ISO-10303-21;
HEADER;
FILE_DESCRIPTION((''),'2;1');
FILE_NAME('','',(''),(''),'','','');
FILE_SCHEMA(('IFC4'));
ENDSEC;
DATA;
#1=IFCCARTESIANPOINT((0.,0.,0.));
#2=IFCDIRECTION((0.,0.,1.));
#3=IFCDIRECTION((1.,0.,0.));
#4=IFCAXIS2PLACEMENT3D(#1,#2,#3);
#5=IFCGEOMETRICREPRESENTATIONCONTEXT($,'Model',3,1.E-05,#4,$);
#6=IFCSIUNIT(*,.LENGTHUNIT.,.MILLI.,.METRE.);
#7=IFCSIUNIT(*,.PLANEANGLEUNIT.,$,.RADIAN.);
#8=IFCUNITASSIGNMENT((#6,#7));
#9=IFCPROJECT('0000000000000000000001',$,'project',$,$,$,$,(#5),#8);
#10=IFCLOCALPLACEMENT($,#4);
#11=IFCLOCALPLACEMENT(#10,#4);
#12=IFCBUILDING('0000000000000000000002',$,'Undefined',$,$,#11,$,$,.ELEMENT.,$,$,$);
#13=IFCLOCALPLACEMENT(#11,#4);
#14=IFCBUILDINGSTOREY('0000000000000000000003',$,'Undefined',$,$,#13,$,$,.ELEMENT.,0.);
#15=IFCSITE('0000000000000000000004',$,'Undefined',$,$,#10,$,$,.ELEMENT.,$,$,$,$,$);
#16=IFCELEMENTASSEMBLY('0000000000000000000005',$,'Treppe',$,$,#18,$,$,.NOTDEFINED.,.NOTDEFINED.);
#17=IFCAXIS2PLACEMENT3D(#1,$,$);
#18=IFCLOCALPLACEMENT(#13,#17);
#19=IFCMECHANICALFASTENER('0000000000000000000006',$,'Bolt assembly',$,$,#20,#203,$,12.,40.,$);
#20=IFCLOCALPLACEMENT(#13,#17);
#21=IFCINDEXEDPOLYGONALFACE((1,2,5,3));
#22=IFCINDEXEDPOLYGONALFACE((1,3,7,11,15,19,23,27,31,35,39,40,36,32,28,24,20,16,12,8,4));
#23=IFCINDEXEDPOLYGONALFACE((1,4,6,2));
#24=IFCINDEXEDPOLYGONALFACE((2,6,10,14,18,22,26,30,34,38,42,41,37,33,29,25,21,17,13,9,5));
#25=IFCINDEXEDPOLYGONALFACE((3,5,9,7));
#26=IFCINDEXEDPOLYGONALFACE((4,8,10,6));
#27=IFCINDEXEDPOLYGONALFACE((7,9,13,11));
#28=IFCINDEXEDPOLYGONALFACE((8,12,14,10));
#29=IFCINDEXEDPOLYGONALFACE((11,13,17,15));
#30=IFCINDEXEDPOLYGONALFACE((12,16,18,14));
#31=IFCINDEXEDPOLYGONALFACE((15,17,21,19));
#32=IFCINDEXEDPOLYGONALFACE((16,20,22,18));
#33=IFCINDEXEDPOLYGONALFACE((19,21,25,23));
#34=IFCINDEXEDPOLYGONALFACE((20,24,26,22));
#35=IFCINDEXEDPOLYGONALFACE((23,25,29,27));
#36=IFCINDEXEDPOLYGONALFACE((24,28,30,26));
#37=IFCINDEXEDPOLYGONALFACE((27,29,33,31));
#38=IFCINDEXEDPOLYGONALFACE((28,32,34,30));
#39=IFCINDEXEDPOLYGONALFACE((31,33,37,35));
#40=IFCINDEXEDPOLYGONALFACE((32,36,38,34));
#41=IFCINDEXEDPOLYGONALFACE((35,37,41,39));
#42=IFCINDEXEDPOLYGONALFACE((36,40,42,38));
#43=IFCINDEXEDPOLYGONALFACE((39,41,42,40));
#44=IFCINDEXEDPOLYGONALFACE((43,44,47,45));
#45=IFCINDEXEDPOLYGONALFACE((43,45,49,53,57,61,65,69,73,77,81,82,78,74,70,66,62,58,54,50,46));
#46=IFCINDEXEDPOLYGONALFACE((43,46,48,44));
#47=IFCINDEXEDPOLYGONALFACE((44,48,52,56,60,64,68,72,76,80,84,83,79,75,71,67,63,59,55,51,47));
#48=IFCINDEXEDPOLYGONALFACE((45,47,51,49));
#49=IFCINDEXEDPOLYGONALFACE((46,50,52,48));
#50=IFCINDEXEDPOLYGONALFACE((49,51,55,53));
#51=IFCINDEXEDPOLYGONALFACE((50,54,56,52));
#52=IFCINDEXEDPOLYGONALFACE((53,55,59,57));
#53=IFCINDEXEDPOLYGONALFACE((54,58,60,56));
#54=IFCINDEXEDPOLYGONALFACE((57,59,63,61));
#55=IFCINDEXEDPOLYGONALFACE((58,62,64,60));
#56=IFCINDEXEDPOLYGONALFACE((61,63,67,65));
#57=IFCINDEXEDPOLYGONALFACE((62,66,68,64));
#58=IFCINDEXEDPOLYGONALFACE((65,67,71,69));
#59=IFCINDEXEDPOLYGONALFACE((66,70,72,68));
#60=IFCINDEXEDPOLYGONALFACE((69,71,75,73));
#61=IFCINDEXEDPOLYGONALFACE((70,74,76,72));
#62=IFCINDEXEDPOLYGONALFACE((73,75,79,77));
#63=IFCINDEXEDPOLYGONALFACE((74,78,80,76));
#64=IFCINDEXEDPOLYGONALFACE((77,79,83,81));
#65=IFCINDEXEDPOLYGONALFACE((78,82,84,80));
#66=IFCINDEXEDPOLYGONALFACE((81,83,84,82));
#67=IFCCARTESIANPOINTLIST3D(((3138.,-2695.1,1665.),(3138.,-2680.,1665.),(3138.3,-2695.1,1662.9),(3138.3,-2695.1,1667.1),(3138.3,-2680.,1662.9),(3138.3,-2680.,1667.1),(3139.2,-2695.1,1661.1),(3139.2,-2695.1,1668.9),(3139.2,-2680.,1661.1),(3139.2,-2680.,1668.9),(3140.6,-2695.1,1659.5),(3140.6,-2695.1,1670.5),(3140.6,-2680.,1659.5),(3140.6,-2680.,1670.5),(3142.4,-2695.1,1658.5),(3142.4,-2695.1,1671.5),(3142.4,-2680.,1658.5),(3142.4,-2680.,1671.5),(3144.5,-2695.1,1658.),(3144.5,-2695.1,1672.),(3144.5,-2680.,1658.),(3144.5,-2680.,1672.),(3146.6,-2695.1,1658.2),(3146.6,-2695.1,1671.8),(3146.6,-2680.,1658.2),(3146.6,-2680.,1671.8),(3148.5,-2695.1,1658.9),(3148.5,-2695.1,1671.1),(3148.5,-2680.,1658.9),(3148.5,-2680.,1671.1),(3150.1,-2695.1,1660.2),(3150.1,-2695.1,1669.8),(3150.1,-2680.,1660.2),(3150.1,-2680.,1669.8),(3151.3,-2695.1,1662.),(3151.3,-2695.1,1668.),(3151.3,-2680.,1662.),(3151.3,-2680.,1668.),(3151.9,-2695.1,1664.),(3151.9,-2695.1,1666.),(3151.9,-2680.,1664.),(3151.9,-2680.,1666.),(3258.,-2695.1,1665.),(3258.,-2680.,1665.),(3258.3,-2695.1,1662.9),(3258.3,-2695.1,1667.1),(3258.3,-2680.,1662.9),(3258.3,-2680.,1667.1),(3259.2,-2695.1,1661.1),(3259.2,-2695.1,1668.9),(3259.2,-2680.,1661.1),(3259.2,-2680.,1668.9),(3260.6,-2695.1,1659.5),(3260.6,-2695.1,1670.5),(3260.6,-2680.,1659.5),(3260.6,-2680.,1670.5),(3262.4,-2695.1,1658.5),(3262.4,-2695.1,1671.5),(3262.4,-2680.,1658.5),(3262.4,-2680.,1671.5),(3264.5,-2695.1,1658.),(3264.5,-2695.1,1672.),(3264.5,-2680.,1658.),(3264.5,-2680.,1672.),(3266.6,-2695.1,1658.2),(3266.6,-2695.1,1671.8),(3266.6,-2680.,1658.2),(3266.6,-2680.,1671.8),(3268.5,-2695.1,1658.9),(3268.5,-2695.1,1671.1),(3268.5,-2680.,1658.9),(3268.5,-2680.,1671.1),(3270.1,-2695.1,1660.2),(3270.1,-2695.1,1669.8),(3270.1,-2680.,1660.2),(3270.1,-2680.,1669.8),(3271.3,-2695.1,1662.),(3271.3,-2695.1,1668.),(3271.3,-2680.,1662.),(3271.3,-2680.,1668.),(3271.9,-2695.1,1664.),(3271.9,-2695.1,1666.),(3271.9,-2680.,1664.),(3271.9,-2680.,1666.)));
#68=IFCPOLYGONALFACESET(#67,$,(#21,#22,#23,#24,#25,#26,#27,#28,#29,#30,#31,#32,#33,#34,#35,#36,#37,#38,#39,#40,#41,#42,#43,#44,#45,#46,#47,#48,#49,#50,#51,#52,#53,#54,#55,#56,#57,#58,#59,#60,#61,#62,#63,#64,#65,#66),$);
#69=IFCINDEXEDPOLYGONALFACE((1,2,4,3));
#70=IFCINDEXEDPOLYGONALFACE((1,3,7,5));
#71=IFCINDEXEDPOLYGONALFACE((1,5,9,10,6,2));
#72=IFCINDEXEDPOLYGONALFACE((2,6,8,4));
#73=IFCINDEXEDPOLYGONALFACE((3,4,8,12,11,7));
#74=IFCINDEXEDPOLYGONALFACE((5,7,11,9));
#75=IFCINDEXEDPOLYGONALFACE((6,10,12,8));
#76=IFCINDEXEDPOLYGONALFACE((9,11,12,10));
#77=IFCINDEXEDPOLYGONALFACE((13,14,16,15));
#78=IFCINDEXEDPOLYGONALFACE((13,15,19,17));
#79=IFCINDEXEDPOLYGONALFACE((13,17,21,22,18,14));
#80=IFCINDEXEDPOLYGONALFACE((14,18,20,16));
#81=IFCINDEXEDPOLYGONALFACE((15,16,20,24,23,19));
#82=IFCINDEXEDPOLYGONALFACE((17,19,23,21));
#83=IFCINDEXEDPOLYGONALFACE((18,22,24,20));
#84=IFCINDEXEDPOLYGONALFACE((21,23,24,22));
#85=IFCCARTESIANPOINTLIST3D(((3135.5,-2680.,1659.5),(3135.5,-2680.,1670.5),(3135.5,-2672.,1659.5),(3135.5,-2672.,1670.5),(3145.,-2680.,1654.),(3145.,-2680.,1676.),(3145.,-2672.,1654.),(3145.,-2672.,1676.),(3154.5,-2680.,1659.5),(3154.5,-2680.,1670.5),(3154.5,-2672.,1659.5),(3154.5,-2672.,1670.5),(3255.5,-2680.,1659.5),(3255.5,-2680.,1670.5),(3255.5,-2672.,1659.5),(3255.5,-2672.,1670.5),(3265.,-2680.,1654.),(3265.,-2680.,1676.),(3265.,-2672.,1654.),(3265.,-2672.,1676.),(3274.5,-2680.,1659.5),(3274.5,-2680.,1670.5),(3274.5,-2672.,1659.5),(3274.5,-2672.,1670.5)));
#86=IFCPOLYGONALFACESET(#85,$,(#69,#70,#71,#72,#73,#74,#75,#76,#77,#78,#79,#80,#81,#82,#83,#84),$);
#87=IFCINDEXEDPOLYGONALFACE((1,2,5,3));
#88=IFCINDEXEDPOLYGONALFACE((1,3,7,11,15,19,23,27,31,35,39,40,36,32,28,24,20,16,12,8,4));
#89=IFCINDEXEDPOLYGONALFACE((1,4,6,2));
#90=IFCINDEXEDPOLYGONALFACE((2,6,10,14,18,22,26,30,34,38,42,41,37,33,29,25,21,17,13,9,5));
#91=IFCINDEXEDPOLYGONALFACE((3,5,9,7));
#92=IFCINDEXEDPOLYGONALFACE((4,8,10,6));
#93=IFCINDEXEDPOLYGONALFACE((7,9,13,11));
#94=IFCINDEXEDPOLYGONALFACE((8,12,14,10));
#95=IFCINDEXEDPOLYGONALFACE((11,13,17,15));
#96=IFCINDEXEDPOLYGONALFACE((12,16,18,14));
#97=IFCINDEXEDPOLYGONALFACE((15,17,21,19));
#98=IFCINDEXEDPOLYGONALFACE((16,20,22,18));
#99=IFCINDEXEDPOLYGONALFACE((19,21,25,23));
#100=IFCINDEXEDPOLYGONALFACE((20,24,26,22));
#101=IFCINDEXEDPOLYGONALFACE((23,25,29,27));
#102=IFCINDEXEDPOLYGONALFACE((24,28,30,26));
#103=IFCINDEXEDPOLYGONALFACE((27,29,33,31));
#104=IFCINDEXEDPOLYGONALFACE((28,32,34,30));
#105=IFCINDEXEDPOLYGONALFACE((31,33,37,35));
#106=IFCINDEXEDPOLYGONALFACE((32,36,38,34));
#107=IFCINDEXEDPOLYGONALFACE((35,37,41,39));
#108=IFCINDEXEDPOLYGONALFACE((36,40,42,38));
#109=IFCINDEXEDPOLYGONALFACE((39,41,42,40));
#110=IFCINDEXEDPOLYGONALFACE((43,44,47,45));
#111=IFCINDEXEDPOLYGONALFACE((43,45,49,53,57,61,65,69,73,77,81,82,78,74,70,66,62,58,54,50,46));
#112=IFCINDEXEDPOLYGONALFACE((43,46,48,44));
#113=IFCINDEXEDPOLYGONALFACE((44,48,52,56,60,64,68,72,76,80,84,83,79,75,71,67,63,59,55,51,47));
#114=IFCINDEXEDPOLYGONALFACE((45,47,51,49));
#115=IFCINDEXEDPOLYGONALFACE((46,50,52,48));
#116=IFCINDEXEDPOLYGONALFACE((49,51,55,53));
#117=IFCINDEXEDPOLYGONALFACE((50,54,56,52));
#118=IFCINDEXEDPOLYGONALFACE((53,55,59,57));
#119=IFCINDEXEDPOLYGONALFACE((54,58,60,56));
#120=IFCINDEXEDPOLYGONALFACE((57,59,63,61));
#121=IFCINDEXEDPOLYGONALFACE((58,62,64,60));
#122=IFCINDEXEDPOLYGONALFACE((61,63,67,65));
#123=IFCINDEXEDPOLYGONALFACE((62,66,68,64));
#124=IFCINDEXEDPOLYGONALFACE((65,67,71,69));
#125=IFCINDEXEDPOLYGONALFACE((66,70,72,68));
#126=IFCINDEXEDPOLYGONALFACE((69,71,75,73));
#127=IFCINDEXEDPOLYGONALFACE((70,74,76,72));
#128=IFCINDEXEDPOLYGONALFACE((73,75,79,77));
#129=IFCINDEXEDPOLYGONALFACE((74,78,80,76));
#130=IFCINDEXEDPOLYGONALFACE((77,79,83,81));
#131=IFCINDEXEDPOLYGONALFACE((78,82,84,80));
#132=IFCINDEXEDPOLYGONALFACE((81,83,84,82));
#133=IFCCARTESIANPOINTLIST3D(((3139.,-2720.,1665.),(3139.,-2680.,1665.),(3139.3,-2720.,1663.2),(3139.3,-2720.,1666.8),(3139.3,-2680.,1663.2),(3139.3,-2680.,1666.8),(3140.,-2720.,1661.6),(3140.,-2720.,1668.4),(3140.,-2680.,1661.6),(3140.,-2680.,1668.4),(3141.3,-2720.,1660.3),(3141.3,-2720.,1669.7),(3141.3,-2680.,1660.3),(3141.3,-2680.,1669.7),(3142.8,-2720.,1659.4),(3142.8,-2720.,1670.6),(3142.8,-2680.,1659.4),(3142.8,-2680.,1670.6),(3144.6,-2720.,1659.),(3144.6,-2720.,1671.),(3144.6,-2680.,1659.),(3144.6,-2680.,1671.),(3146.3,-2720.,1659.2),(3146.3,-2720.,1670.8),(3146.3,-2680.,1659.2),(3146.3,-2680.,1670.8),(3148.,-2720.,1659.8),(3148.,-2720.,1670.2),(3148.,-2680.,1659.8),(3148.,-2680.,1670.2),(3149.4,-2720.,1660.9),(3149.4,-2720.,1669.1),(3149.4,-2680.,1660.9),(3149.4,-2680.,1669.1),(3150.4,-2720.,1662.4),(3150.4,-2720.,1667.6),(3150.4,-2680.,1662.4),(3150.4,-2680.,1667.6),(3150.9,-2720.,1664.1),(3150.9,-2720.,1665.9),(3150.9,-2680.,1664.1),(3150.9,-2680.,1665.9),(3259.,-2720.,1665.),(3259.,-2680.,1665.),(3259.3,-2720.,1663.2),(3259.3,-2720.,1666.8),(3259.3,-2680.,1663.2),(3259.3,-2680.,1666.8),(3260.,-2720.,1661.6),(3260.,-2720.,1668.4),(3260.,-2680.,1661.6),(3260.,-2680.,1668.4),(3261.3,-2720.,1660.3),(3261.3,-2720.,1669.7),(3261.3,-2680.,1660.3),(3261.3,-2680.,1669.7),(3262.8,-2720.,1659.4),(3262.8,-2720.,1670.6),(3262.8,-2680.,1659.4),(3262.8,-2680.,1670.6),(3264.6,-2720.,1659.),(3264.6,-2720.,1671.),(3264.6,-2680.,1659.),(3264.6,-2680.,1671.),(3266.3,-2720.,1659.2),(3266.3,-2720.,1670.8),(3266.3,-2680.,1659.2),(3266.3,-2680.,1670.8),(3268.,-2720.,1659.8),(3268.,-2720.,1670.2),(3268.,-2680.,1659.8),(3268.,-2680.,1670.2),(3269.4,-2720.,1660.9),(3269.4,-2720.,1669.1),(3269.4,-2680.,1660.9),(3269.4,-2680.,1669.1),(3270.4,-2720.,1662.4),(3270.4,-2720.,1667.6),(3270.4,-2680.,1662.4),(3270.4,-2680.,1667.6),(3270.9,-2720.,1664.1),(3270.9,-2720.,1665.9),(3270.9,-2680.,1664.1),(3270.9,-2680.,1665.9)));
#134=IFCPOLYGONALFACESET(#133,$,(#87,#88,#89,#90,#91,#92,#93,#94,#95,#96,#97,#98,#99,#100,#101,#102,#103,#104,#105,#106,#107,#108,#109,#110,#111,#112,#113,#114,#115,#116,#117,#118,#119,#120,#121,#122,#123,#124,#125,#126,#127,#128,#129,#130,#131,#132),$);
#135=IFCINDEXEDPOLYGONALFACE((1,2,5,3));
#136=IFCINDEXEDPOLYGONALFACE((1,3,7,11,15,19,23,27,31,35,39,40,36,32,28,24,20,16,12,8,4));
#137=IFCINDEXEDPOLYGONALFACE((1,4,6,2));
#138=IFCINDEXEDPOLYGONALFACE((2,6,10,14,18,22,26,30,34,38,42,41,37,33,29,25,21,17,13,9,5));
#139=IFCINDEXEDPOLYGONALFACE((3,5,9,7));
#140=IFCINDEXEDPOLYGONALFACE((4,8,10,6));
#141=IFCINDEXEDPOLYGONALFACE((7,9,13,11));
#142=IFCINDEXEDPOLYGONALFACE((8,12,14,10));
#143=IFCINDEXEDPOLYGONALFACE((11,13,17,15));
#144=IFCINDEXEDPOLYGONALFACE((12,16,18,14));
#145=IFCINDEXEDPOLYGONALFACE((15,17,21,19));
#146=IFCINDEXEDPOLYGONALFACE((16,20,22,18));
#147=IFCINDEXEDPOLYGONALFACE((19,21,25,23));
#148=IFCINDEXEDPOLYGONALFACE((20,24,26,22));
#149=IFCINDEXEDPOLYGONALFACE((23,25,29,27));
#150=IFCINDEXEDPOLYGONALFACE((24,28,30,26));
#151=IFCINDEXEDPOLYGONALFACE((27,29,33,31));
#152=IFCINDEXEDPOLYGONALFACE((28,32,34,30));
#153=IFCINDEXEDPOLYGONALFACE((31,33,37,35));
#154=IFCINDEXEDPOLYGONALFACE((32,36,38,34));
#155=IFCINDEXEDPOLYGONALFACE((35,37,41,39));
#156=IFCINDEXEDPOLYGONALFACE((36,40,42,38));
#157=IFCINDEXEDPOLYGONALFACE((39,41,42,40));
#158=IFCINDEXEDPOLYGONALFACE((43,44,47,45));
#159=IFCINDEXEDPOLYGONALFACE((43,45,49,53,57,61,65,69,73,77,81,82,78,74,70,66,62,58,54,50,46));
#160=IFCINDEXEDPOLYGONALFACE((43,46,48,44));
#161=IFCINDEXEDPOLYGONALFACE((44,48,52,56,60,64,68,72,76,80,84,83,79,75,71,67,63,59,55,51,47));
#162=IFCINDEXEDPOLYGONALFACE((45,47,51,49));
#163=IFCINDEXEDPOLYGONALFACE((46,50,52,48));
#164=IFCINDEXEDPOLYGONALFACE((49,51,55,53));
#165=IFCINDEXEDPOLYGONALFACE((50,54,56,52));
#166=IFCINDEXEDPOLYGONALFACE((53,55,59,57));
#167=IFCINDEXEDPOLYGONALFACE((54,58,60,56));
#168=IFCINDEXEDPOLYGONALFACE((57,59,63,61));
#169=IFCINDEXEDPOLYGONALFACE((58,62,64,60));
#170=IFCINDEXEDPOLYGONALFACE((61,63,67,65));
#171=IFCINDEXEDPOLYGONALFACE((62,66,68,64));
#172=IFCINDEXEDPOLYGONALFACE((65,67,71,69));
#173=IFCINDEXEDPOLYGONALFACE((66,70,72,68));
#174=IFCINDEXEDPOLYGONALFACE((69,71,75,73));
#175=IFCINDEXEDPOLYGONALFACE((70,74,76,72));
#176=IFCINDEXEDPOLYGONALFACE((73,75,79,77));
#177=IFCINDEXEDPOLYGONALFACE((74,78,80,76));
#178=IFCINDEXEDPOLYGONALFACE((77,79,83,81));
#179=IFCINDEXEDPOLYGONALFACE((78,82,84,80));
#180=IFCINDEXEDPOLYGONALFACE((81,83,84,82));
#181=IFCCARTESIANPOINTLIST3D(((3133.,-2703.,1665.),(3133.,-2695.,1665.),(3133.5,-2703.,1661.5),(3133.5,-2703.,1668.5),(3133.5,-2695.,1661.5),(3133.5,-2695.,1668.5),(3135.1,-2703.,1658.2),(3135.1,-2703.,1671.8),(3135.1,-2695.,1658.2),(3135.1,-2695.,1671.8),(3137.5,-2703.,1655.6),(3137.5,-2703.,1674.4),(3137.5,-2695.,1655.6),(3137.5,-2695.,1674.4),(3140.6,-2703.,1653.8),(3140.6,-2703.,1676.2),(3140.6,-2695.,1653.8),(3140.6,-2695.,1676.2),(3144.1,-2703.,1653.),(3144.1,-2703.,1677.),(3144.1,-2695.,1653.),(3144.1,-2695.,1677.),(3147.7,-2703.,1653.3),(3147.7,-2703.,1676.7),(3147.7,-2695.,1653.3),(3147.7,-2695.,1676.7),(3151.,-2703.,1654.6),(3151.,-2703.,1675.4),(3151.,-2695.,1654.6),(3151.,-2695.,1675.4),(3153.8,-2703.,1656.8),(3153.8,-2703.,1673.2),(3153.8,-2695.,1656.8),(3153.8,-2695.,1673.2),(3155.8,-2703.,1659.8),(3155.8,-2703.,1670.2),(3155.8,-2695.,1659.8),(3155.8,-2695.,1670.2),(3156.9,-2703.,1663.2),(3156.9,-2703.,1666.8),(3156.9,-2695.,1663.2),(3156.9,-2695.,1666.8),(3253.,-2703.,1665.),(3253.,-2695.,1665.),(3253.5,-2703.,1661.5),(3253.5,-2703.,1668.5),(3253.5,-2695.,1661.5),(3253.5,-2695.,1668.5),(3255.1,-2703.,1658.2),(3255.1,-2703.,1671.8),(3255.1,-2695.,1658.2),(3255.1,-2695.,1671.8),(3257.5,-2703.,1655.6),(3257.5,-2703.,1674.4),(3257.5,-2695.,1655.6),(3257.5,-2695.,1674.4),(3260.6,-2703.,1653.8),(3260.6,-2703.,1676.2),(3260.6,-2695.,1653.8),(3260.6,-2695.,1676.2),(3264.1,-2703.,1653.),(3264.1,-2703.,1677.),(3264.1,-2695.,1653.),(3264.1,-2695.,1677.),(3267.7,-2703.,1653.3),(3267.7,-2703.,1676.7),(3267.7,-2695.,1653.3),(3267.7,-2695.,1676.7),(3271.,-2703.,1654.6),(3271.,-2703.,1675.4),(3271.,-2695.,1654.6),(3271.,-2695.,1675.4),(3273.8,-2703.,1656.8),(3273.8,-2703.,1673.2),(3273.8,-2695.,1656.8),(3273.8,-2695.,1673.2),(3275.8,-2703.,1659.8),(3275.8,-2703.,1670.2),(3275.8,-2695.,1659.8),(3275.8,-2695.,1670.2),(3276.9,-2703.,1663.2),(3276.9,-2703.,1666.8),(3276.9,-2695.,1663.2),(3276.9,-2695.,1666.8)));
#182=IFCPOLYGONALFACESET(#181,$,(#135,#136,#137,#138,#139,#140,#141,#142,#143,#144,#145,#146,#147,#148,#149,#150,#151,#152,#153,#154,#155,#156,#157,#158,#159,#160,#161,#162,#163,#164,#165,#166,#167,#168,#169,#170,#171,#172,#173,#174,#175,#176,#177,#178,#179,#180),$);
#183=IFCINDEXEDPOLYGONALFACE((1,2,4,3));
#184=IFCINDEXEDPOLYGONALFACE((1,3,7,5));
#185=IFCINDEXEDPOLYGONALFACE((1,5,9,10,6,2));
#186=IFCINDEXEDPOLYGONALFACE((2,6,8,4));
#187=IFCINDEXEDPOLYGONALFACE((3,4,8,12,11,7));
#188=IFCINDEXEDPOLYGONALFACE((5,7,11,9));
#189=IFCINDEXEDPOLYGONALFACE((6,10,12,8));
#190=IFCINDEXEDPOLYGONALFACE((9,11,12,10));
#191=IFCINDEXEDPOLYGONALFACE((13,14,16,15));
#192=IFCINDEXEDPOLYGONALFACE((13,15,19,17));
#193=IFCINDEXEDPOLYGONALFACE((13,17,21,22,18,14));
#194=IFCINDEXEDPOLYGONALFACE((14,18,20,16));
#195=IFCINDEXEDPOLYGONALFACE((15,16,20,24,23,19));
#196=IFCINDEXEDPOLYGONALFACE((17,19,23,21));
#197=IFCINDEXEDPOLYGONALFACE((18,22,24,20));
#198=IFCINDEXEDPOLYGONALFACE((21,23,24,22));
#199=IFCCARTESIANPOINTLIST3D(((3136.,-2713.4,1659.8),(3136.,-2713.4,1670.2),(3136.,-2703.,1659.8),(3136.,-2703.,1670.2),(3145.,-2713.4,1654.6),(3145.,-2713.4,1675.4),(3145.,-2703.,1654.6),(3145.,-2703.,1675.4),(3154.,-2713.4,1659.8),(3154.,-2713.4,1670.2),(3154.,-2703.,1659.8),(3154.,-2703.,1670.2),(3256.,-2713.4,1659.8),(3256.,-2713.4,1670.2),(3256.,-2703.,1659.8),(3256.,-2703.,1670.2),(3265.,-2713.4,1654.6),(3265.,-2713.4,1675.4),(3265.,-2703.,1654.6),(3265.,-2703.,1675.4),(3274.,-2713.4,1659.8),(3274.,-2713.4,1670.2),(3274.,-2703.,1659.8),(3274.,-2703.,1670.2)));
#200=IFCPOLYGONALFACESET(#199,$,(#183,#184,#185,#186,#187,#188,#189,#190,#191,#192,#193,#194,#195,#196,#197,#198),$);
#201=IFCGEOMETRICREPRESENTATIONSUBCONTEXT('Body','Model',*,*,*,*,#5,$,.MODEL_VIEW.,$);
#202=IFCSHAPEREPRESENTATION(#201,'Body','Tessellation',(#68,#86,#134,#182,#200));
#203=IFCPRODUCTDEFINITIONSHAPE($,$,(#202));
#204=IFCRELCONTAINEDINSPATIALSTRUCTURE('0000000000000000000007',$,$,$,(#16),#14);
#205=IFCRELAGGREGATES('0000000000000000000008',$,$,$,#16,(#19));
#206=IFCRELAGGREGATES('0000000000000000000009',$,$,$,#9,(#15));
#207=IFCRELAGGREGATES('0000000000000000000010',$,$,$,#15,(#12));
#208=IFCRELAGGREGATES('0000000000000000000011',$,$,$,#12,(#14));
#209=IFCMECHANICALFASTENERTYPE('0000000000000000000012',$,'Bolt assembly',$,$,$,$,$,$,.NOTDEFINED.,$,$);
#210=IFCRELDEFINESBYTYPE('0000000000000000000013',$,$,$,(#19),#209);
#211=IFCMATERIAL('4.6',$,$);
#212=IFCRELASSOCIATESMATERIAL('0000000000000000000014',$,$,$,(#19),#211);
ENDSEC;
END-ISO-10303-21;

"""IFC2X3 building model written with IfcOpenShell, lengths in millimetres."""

from ifc_helpers import new_model, si_unit, frame, origin_with_axes, origin_2d_with_axis, place, context, subcontext, project, spatial, polyline, circle, outline, extrude, source, transform, mapped, material, type_object, element, aggregate, save


model = new_model("IFC2X3")

# Units and contexts
model_context = context("Model", 3, precision=1e-05, world=origin_with_axes())
body_context = subcontext(model_context, "Body", "Model", "MODEL_VIEW")
ifc_project = project(units=[si_unit("LENGTHUNIT", "METRE", prefix="MILLI"), si_unit("PLANEANGLEUNIT", "RADIAN")], contexts=[model_context])

# Site, building, storey
site_placement = place(None, origin_with_axes())
site = spatial("IfcSite", under=ifc_project, at=site_placement, Name="Undefined", CompositionType="ELEMENT")
building_placement = place(site_placement, origin_with_axes())
building = spatial("IfcBuilding", under=site, at=building_placement, Name="Undefined", CompositionType="ELEMENT")
storey_placement = place(building_placement, origin_with_axes())
storey = spatial("IfcBuildingStorey", under=building, at=storey_placement, Name="Undefined", CompositionType="ELEMENT", Elevation=0.0)

# Element assembly, mechanical fastener
ifc_material_1 = material(Name="4.6")
mechanical_fastener_type = type_object("IfcMechanicalFastenerType", Name="Bolt assembly")
assembly_1_placement = place(storey_placement, origin_with_axes())
assembly_1 = element("IfcElementAssembly", 1, at=assembly_1_placement, inside=storey, Name="Treppe", AssemblyPlace="NOTDEFINED", PredefinedType="NOTDEFINED")
shared_shape_1 = source(origin_with_axes(), body_context, "Body", "SweptSolid", [
    extrude(circle(Radius=7.0, at=origin_2d_with_axis()), frame((0.0, -15.0, 0.0), z_axis=(0.0, 1.0, 0.0), x_axis=(1.0, 0.0, 0.0)), (0.0, 0.0, 1.0), 15.1),
    extrude(outline(polyline([(9.5, -5.5), (9.5, 5.5), (0.0, 11.0), (-9.5, 5.5), (-9.5, -5.5), (0.0, -11.0), (9.5, -5.5)])), frame((0.0, -23.0, 0.0), z_axis=(0.0, 1.0, 0.0), x_axis=(1.0, 0.0, 0.0)), (0.0, 0.0, 1.0), 8.0),
    extrude(circle(Radius=6.0, at=origin_2d_with_axis()), frame((0.0, -15.0, 0.0), z_axis=(0.0, 1.0, 0.0), x_axis=(1.0, 0.0, 0.0)), (0.0, 0.0, 1.0), 40.0),
    extrude(circle(Radius=12.0, at=origin_2d_with_axis()), frame((0.0, 0.0, 0.0), z_axis=(0.0, 1.0, 0.0), x_axis=(1.0, 0.0, 0.0)), (0.0, 0.0, 1.0), 8.0),
    extrude(outline(polyline([(9.0, -5.2), (9.0, 5.2), (0.0, 10.4), (-9.0, 5.2), (-9.0, -5.2), (0.0, -10.4), (9.0, -5.2)])), frame((0.0, 8.0, 0.0), z_axis=(0.0, 1.0, 0.0), x_axis=(1.0, 0.0, 0.0)), (0.0, 0.0, 1.0), 10.4),
])
mechanical_fastener_1_placement = place(assembly_1_placement, frame((3265.0, -2695.0, 1665.0), z_axis=(0.0, 0.0, 1.0), x_axis=(-1.0, 0.0, 0.0)))
mechanical_fastener_1 = element("IfcMechanicalFastener", 2, at=mechanical_fastener_1_placement, type_object=mechanical_fastener_type, material=ifc_material_1, Name="Bolt assembly", NominalDiameter=12.0, NominalLength=40.0, context=body_context, shape_type="MappedRepresentation", body=[
    mapped(shared_shape_1, transform((0.0, 0.0, 0.0))),
    mapped(shared_shape_1, transform((120.0, 0.0, 0.0))),
])
aggregate(assembly_1, [mechanical_fastener_1])

save(model, "model.ifc")
